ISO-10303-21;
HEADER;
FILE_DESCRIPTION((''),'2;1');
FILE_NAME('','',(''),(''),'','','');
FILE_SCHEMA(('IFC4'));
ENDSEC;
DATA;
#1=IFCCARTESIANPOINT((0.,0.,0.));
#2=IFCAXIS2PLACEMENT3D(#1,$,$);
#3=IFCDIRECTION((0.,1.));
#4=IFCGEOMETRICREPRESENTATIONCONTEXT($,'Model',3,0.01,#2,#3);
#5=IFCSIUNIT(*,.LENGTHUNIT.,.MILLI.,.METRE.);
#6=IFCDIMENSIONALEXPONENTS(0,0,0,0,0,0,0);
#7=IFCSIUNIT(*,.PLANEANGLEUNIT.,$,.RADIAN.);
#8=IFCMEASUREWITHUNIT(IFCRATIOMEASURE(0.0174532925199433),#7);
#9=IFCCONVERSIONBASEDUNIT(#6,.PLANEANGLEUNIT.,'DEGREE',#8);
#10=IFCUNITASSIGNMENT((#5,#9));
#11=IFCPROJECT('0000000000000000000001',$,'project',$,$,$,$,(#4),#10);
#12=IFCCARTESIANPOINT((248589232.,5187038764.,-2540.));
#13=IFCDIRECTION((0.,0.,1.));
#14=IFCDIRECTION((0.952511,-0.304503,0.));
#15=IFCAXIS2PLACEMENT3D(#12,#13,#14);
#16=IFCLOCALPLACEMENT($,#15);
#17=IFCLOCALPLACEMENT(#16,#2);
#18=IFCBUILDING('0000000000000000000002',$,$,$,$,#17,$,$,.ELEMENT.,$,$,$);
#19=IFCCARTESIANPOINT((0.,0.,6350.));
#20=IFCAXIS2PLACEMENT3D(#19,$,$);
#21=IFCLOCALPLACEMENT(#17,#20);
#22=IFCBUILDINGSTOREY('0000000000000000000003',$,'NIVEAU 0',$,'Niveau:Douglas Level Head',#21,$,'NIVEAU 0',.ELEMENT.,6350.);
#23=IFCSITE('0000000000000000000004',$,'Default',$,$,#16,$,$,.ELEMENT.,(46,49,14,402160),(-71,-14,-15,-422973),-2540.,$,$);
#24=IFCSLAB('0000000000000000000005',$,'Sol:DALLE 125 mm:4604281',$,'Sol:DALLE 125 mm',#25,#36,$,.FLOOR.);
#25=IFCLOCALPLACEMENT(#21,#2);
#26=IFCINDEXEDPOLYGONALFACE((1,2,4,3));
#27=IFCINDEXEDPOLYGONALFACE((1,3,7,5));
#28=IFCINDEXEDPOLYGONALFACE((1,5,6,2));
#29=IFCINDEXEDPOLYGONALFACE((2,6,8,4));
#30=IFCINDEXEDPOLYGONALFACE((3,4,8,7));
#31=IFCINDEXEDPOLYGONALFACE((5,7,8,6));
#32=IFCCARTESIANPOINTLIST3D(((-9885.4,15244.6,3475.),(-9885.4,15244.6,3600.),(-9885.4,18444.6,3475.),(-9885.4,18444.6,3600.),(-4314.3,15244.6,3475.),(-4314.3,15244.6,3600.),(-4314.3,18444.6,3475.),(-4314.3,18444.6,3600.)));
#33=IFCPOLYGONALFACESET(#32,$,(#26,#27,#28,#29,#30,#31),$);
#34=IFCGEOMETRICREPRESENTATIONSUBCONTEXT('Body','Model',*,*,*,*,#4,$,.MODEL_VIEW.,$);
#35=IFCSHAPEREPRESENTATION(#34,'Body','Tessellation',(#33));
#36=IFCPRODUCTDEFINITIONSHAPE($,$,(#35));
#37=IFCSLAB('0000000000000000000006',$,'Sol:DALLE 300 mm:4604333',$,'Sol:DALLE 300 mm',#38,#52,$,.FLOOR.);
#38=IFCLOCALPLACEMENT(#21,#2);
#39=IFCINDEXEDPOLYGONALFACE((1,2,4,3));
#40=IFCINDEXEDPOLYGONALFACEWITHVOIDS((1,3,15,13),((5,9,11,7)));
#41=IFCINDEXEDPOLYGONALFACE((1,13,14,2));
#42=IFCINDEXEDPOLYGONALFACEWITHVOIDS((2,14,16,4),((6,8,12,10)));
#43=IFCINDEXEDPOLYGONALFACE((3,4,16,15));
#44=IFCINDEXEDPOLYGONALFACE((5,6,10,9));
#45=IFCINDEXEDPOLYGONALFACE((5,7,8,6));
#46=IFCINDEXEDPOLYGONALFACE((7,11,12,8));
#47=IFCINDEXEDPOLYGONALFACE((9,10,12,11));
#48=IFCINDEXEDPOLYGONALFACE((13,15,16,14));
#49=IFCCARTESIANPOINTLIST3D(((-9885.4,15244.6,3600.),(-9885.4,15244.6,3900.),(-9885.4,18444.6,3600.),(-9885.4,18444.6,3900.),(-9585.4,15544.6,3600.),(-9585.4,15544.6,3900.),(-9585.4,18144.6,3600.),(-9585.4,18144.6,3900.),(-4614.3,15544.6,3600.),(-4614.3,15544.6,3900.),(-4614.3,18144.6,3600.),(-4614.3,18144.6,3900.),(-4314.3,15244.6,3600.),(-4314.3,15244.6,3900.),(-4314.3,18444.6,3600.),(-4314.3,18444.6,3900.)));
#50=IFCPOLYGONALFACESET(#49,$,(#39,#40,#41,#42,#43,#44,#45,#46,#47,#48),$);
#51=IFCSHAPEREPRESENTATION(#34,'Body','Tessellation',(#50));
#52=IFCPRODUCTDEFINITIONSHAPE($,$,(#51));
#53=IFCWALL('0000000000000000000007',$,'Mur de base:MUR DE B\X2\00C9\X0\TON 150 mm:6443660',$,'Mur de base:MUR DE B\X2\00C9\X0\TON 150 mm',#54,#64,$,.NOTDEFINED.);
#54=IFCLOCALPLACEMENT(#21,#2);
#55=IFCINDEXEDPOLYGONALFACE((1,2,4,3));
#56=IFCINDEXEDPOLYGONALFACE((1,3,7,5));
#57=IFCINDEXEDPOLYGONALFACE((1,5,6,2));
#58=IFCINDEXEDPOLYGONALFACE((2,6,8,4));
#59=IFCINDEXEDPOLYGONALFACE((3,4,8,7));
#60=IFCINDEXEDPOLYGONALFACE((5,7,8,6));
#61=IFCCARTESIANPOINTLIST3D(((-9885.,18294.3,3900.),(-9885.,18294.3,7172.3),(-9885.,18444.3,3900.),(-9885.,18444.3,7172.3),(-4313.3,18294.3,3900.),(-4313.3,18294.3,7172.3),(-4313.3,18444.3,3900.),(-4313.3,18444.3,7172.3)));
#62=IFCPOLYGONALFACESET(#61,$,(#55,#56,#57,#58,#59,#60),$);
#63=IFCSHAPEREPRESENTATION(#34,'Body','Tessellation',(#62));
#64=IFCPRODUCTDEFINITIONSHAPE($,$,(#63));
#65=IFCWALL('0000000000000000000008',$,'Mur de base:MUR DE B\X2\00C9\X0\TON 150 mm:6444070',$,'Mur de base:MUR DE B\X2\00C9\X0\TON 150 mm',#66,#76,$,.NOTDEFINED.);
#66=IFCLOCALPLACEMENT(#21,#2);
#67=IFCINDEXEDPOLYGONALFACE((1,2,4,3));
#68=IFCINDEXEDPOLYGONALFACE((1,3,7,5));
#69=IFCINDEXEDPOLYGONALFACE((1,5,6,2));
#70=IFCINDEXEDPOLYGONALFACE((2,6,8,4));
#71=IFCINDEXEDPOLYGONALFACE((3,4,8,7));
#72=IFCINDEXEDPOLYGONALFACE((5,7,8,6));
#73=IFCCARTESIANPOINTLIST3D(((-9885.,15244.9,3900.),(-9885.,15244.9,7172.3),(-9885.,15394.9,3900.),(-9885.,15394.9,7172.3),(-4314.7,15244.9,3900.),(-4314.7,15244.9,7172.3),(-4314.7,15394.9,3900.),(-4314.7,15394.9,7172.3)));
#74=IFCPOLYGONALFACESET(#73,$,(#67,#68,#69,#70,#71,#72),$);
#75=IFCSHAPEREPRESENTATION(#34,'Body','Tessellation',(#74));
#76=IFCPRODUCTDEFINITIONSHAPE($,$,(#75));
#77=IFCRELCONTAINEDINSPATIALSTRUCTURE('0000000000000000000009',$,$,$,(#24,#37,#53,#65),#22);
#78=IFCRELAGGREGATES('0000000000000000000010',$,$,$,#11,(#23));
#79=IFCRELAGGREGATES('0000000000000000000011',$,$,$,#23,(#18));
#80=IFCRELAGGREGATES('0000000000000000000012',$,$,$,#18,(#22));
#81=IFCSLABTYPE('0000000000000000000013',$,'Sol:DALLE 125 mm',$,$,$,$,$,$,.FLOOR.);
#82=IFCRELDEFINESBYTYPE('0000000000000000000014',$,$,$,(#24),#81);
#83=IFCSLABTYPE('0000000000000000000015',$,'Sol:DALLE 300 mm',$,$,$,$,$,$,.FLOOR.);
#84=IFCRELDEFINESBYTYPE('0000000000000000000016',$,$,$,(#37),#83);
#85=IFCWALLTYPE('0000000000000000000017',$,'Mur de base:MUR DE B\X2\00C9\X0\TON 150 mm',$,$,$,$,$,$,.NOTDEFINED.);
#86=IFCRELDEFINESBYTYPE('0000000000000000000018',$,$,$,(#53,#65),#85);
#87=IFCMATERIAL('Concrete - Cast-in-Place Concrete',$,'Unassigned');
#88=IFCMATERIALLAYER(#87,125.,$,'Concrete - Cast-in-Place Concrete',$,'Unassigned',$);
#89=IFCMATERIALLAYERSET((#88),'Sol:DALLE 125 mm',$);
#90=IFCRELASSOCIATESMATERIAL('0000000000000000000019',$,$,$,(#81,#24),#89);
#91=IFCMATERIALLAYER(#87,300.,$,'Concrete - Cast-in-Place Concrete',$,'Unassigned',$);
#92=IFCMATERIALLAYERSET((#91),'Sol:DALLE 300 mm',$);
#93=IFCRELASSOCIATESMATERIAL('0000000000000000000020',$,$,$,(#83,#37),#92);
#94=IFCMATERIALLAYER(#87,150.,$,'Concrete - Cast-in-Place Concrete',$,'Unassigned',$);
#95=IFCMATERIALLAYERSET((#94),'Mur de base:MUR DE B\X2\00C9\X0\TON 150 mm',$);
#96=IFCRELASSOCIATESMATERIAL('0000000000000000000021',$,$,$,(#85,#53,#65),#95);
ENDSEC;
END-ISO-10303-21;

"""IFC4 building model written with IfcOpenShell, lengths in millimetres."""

from ifc_helpers import new_model, entity, si_unit, converted_unit, direction, frame, origin, place, context, subcontext, project, spatial, indexed_curve, outline, extrude, material, layer, layer_set, type_object, element, save


model = new_model("IFC4")

# Units and contexts
model_context = context("Model", 3, precision=0.01, world=origin(), true_north=direction((0.0, 1.0)))
body_context = subcontext(model_context, "Body", "Model", "MODEL_VIEW")
ifc_project = project(units=[si_unit("LENGTHUNIT", "METRE", prefix="MILLI"), converted_unit("PLANEANGLEUNIT", "DEGREE", entity("IfcRatioMeasure", 0.0174532925199433), si_unit("PLANEANGLEUNIT", "RADIAN"), dimensions=[0, 0, 0, 0, 0, 0, 0])], contexts=[model_context])

# Site, building, storey
site_placement = place(None, frame((248589232.0, 5187038764.0, -2540.0), z_axis=(0.0, 0.0, 1.0), x_axis=(0.952511, -0.304503, 0.0)))
site = spatial("IfcSite", under=ifc_project, at=site_placement, Name="Default", CompositionType="ELEMENT", RefLatitude=(46, 49, 14, 402160), RefLongitude=(-71, -14, -15, -422973), RefElevation=-2540.0)
building_placement = place(site_placement, origin())
building = spatial("IfcBuilding", under=site, at=building_placement, CompositionType="ELEMENT")
storey_placement = place(building_placement, frame((0.0, 0.0, 6350.0)))
storey = spatial("IfcBuildingStorey", under=building, at=storey_placement, Name="NIVEAU 0", ObjectType="Niveau:Douglas Level Head", LongName="NIVEAU 0", CompositionType="ELEMENT", Elevation=6350.0)

# Slabs
ifc_material = material(Name="Concrete - Cast-in-Place Concrete", Category="Unassigned")
ifc_layer_1 = layer(ifc_material, 125.0, Name="Concrete - Cast-in-Place Concrete", Category="Unassigned")
ifc_layer_set_1 = layer_set([ifc_layer_1], Name="Sol:DALLE 125 mm")
slab_type_1 = type_object("IfcSlabType", Name="Sol:DALLE 125 mm", PredefinedType="FLOOR", material=ifc_layer_set_1)
slab_1_placement = place(storey_placement, origin())
element("IfcSlab", 1, at=slab_1_placement, inside=storey, type_object=slab_type_1, material=ifc_layer_set_1, Name="Sol:DALLE 125 mm:4604281", ObjectType="Sol:DALLE 125 mm", PredefinedType="FLOOR", context=body_context, shape_type="SweptSolid", body=[
    extrude(outline(indexed_curve([(-1600.0, -2785.5), (1600.0, -2785.5), (1600.0, 2785.5), (-1600.0, 2785.5), (-1600.0, -2785.5)], self_intersect=False)), frame((-7099.8, 16844.6, 3600.0), z_axis=(0.0, 0.0, -1.0), x_axis=(0.0, 1.0, 0.0)), (0.0, 0.0, 1.0), 125.0),
])
ifc_layer_2 = layer(ifc_material, 300.0, Name="Concrete - Cast-in-Place Concrete", Category="Unassigned")
ifc_layer_set_2 = layer_set([ifc_layer_2], Name="Sol:DALLE 300 mm")
slab_type_2 = type_object("IfcSlabType", Name="Sol:DALLE 300 mm", PredefinedType="FLOOR", material=ifc_layer_set_2)
slab_2_placement = place(storey_placement, origin())
element("IfcSlab", 2, at=slab_2_placement, inside=storey, type_object=slab_type_2, material=ifc_layer_set_2, Name="Sol:DALLE 300 mm:4604333", ObjectType="Sol:DALLE 300 mm", PredefinedType="FLOOR", context=body_context, shape_type="SweptSolid", body=[
    extrude(outline(indexed_curve([(-2785.5, -1600.0), (2785.5, -1600.0), (2785.5, 1600.0), (-2785.5, 1600.0), (-2785.5, -1600.0)], self_intersect=False), holes=[indexed_curve([(-2485.5, -1300.0), (-2485.5, 1300.0), (2485.5, 1300.0), (2485.5, -1300.0), (-2485.5, -1300.0)], self_intersect=False)]), frame((-7099.8, 16844.6, 3600.0), z_axis=(0.0, 0.0, 1.0), x_axis=(-1.0, 0.0, 0.0)), (0.0, 0.0, 1.0), 300.0),
])

# Walls
ifc_layer_3 = layer(ifc_material, 150.0, Name="Concrete - Cast-in-Place Concrete", Category="Unassigned")
ifc_layer_set_3 = layer_set([ifc_layer_3], Name="Mur de base:MUR DE BÉTON 150 mm")
wall_type = type_object("IfcWallType", Name="Mur de base:MUR DE BÉTON 150 mm", PredefinedType="NOTDEFINED", material=ifc_layer_set_3)
wall_1_placement = place(storey_placement, frame((-9885.0, 18369.3, 3900.0)))
element("IfcWall", 3, at=wall_1_placement, inside=storey, type_object=wall_type, material=ifc_layer_set_3, Name="Mur de base:MUR DE BÉTON 150 mm:6443660", ObjectType="Mur de base:MUR DE BÉTON 150 mm", PredefinedType="NOTDEFINED", context=body_context, shape_type="SweptSolid", body=[
    extrude(outline(indexed_curve([(5571.7, 75.0), (0.0, 75.0), (0.0, -75.0), (5571.7, -75.0), (5571.7, 75.0)], self_intersect=False)), origin(), (0.0, 0.0, 1.0), 3272.3),
])
wall_2_placement = place(storey_placement, frame((-9885.0, 15319.9, 3900.0)))
element("IfcWall", 4, at=wall_2_placement, inside=storey, type_object=wall_type, material=ifc_layer_set_3, Name="Mur de base:MUR DE BÉTON 150 mm:6444070", ObjectType="Mur de base:MUR DE BÉTON 150 mm", PredefinedType="NOTDEFINED", context=body_context, shape_type="SweptSolid", body=[
    extrude(outline(indexed_curve([(5570.3, 75.0), (0.0, 75.0), (0.0, -75.0), (5570.3, -75.0), (5570.3, 75.0)], self_intersect=False)), origin(), (0.0, 0.0, 1.0), 3272.3),
])

save(model, "model.ifc")
